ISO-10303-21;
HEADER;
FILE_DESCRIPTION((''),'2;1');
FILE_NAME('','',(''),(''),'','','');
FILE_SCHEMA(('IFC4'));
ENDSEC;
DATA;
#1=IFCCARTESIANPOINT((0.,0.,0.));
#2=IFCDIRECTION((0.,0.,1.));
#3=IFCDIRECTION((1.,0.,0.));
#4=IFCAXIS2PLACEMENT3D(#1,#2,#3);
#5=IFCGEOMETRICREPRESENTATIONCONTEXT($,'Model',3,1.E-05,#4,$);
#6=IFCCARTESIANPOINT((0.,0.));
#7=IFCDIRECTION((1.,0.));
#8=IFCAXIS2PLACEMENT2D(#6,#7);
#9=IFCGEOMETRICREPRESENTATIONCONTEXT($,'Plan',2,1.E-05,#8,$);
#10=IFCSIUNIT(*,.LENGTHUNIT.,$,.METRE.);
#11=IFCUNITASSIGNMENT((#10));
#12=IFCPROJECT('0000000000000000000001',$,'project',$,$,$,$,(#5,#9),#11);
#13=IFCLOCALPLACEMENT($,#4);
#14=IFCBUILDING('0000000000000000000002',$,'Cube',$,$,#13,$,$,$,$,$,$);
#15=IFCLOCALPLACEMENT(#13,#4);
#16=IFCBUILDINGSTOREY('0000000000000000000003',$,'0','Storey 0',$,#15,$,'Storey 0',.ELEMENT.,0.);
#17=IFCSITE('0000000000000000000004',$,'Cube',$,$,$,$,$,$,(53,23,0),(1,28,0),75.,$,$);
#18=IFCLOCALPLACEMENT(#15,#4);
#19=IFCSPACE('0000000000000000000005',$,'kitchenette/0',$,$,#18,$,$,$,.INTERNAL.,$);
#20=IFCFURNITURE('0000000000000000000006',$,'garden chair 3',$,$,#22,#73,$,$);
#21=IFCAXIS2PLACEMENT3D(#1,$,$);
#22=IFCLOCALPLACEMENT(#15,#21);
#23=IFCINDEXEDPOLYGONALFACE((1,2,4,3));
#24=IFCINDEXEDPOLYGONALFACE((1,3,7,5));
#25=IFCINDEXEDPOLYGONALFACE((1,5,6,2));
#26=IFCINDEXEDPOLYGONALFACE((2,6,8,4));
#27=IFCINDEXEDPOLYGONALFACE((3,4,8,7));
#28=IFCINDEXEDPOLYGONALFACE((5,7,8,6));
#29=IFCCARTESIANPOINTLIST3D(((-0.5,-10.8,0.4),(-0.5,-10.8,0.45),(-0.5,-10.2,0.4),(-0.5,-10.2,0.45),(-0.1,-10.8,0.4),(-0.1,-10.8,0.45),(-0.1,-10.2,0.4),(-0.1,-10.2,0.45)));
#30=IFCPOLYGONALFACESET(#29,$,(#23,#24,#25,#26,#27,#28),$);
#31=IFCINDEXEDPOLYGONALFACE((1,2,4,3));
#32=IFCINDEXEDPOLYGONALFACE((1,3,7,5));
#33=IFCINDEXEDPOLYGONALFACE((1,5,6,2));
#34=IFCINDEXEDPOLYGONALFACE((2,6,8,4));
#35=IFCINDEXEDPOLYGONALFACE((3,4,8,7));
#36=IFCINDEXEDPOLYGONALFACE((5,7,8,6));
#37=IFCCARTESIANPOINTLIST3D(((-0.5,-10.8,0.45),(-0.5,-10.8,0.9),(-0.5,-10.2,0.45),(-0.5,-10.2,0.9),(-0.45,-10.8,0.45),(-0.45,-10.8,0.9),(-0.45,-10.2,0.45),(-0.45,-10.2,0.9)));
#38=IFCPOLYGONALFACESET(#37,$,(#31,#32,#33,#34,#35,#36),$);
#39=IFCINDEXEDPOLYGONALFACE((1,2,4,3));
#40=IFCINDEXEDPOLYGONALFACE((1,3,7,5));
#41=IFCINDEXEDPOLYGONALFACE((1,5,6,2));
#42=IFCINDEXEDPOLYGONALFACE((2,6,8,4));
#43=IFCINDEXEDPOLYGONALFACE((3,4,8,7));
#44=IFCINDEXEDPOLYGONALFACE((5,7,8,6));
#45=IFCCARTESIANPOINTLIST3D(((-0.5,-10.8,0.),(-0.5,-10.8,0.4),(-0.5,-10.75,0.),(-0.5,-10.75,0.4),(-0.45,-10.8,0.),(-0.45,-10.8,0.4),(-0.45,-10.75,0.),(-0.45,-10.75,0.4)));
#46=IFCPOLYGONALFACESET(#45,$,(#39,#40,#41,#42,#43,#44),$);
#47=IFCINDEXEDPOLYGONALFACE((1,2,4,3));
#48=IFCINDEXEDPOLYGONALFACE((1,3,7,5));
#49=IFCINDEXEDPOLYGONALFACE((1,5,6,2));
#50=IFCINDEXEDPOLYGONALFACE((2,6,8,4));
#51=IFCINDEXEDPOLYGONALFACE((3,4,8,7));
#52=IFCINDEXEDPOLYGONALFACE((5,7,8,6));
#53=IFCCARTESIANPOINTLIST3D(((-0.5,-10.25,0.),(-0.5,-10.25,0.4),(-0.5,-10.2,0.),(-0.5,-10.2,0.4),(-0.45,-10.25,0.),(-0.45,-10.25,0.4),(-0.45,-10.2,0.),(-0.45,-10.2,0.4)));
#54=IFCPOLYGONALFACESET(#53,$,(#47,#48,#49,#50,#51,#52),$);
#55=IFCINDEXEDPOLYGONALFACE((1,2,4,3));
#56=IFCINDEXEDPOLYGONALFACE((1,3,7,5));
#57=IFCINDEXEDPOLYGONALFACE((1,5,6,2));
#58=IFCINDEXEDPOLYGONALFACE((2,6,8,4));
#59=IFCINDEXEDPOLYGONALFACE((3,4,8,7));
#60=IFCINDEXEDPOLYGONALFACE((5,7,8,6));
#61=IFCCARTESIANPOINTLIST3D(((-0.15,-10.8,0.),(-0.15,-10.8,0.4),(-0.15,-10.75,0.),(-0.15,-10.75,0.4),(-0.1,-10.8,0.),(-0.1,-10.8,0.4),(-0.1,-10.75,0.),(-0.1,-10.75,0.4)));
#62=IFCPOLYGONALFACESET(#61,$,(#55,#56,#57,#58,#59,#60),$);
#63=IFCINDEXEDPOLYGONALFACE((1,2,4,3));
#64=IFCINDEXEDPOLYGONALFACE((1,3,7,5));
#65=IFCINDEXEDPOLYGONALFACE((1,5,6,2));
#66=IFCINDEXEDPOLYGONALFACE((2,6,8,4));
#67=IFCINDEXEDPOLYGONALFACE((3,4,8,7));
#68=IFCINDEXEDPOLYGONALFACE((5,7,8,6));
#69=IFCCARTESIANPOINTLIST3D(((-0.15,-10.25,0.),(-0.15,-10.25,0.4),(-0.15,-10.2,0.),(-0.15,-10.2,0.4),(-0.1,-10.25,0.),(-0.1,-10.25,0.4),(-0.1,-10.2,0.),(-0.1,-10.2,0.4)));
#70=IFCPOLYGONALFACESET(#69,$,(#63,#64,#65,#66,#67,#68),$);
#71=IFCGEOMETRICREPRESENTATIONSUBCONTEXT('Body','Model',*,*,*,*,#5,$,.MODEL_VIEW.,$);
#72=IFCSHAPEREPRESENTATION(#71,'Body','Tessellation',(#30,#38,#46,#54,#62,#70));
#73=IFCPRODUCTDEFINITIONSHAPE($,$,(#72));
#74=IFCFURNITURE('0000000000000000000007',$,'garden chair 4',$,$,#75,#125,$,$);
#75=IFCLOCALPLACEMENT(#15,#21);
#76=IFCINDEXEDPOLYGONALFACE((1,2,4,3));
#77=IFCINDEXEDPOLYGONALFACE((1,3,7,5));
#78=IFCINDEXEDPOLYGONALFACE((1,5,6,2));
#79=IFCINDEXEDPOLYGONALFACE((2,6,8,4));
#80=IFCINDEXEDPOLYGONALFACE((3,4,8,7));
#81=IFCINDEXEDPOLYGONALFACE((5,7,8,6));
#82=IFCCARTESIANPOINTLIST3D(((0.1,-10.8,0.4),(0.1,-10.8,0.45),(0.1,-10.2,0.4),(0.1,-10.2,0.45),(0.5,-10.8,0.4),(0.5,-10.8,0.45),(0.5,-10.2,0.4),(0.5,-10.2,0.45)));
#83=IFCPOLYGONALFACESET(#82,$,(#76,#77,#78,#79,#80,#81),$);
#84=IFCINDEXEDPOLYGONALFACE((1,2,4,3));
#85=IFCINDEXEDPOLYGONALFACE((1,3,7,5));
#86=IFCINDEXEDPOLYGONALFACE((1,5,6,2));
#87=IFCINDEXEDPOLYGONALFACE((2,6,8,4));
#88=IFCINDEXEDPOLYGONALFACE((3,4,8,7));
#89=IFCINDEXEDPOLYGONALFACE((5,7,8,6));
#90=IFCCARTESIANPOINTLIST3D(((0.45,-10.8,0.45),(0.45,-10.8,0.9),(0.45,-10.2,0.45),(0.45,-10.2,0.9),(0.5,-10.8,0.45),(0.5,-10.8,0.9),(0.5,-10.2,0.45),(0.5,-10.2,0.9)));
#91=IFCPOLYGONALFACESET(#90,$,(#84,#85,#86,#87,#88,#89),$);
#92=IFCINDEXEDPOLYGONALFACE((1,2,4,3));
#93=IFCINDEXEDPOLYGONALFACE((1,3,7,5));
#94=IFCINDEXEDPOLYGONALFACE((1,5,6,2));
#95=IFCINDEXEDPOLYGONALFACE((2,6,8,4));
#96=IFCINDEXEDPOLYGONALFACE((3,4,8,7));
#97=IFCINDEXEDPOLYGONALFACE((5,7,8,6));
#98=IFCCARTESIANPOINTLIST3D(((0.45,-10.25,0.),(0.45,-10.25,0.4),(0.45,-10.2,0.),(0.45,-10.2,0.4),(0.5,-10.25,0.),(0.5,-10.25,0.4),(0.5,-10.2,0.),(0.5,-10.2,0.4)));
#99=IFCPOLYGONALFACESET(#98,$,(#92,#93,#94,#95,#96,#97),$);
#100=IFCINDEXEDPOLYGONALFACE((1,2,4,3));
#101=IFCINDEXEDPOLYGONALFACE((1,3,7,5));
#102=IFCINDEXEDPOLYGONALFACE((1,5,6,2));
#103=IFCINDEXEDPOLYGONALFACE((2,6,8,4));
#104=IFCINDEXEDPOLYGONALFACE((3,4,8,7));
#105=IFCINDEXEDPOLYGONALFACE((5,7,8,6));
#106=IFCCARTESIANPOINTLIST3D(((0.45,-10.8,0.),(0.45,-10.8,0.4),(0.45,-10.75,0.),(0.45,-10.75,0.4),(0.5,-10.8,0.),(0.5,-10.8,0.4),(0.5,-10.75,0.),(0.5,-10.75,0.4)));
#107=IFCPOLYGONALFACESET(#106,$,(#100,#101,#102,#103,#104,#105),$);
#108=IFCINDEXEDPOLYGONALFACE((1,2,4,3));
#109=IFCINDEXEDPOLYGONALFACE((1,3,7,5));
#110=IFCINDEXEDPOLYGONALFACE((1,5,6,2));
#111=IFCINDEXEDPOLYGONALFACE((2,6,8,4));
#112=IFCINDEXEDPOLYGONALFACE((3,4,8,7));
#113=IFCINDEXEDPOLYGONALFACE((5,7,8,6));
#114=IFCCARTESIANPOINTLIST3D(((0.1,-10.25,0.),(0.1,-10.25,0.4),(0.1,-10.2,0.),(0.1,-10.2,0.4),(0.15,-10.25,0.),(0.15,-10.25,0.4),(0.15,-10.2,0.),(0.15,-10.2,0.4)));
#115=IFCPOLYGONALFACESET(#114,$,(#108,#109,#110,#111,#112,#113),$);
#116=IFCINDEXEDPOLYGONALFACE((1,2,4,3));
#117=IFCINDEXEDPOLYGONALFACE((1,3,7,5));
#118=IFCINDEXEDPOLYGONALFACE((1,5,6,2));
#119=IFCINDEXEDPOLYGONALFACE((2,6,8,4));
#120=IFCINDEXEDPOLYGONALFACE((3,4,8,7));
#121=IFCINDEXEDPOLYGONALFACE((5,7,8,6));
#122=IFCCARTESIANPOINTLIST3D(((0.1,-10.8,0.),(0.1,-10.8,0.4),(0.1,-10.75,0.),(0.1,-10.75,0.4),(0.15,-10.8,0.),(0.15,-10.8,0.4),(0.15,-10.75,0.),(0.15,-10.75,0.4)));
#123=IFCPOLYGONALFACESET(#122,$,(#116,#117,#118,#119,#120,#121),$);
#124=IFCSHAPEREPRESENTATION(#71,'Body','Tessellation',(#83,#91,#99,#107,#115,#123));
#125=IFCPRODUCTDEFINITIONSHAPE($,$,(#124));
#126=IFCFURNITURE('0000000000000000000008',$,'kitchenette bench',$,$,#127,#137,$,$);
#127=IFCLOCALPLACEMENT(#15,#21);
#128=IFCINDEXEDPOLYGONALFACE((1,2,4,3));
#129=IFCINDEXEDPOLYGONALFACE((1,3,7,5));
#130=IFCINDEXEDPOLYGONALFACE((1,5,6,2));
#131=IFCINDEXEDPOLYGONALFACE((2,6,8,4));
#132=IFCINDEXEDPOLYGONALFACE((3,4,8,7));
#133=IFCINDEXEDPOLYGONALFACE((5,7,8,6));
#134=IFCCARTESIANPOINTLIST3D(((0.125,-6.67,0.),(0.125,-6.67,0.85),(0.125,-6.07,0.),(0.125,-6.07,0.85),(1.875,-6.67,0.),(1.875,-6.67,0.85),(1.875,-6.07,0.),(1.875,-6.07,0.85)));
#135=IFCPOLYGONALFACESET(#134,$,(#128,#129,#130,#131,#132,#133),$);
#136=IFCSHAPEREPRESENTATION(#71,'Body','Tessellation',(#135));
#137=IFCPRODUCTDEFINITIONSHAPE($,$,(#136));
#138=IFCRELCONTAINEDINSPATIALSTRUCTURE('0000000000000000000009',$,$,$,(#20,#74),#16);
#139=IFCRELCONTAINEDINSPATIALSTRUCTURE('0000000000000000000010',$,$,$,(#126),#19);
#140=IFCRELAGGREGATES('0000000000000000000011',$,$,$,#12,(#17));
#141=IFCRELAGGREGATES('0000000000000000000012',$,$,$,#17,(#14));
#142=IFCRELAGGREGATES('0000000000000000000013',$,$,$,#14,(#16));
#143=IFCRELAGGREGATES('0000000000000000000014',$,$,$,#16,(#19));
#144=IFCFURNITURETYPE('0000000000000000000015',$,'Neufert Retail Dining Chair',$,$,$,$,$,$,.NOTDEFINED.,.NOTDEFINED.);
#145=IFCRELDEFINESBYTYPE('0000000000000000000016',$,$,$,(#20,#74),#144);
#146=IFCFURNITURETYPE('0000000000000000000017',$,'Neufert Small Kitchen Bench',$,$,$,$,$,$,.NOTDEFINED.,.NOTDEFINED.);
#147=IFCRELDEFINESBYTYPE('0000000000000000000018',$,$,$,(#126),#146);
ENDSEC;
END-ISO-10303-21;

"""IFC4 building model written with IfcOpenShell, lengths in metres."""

from ifc_helpers import new_model, entity, si_unit, frame, origin_with_axes, origin_2d_with_axis, place, context, subcontext, project, spatial, line, indexed_curve, outline, extrude, shape, source, transform, mapped, type_object, type_shapes, element, save


model = new_model("IFC4")

# Units and contexts
model_context = context("Model", 3, precision=1e-05, world=origin_with_axes())
plan_context = context("Plan", 2, precision=1e-05, world=origin_2d_with_axis())
body_context_1 = subcontext(model_context, "Body", "Model", "MODEL_VIEW")
body_context_2 = subcontext(plan_context, "Body", "Plan", "PLAN_VIEW")
ifc_project = project(units=[si_unit("LENGTHUNIT", "METRE")], contexts=[model_context, plan_context])

# Site, building, storey
site = spatial("IfcSite", under=ifc_project, Name="Cube", RefLatitude=(53, 23, 0), RefLongitude=(1, 28, 0), RefElevation=75.0)
building_placement = place(None, origin_with_axes())
building = spatial("IfcBuilding", under=site, at=building_placement, Name="Cube")
storey_placement = place(building_placement, origin_with_axes())
storey = spatial("IfcBuildingStorey", under=building, at=storey_placement, Name="0", Description="Storey 0", LongName="Storey 0", CompositionType="ELEMENT", Elevation=0.0)

# Shared definitions
space_1_placement = place(storey_placement, origin_with_axes())
space_1 = spatial("IfcSpace", under=storey, at=space_1_placement, Name="kitchenette/0", PredefinedType="INTERNAL")

# Furniture
furniture_type_1 = type_object("IfcFurnitureType", Name="Neufert Retail Dining Chair", AssemblyPlace="NOTDEFINED", PredefinedType="NOTDEFINED")
shared_shape_1 = source(origin_with_axes(), body_context_1, "Body", "SweptSolid", [
    extrude(outline(indexed_curve([(-0.3, 0.0), (0.3, 0.0), (0.3, -0.4), (-0.3, -0.4)], segments=[line(1, 2, 3, 4, 1)])), frame((0.0, 0.0, 0.45), z_axis=(0.0, 0.0, 1.0), x_axis=(1.0, 0.0, 0.0)), (0.0, 0.0, -1.0), 0.05),
    extrude(outline(indexed_curve([(-0.3, 0.0), (0.3, 0.0), (0.3, -0.05), (-0.3, -0.05)], segments=[line(1, 2, 3, 4, 1)])), frame((0.0, 0.0, 0.9), z_axis=(0.0, 0.0, 1.0), x_axis=(1.0, 0.0, 0.0)), (0.0, 0.0, -1.0), 0.45),
    extrude(outline(indexed_curve([(-0.3, 0.0), (-0.25, 0.0), (-0.25, -0.05), (-0.3, -0.05)], segments=[line(1, 2, 3, 4, 1)])), origin_with_axes(), (0.0, 0.0, 1.0), 0.4),
    extrude(outline(indexed_curve([(0.3, 0.0), (0.25, 0.0), (0.25, -0.05), (0.3, -0.05)], segments=[line(1, 2, 3, 4, 1)])), origin_with_axes(), (0.0, 0.0, 1.0), 0.4),
    extrude(outline(indexed_curve([(-0.3, -0.4), (-0.25, -0.4), (-0.25, -0.35), (-0.3, -0.35)], segments=[line(1, 2, 3, 4, 1)])), origin_with_axes(), (0.0, 0.0, 1.0), 0.4),
    extrude(outline(indexed_curve([(0.3, -0.4), (0.25, -0.4), (0.25, -0.35), (0.3, -0.35)], segments=[line(1, 2, 3, 4, 1)])), origin_with_axes(), (0.0, 0.0, 1.0), 0.4),
])
shared_shape_2 = source(origin_with_axes(), body_context_2, "Body", "Curve2D", [
    entity("IfcIndexedPolyCurve", entity("IfcCartesianPointList2D", [[-0.3, -0.4], [0.3, -0.4]])),
    entity("IfcIndexedPolyCurve", entity("IfcCartesianPointList2D", [[-0.3, -0.4], [-0.3, -0.3], [-0.2121, -0.0879], [0.0, 0.0], [0.2121, -0.0879], [0.3, -0.3], [0.3, -0.4]]), [entity("IfcLineIndex", [1, 2]), entity("IfcArcIndex", [2, 3, 4]), entity("IfcArcIndex", [4, 5, 6]), entity("IfcLineIndex", [6, 7])]),
    entity("IfcIndexedPolyCurve", entity("IfcCartesianPointList2D", [[-0.26, -0.4], [-0.26, -0.3], [-0.1838, -0.1162], [0.0, -0.04], [0.1838, -0.1162], [0.26, -0.3], [0.26, -0.4]]), [entity("IfcLineIndex", [1, 2]), entity("IfcArcIndex", [2, 3, 4]), entity("IfcArcIndex", [4, 5, 6]), entity("IfcLineIndex", [6, 7])]),
])
type_shapes(furniture_type_1, [shared_shape_1, shared_shape_2])
for number, where, z_axis, x_axis, name in (
    (1, (-0.5, -10.5, 0.0), (0.0, 0.0, 1.0), (0.0, 1.0, 0.0), "garden chair 3"),
    (2, (0.5, -10.5, 0.0), (0.0, 0.0, 1.0), (0.0, -1.0, 0.0), "garden chair 4"),
):
    element("IfcFurniture", number, at=place(storey_placement, frame(where, z_axis=z_axis, x_axis=x_axis)), inside=storey, type_object=furniture_type_1, Name=name, shapes=[
        shape(body_context_1, "Body", "MappedRepresentation", [mapped(shared_shape_1, transform((0.0, 0.0, 0.0), x_axis=(1.0, 0.0, 0.0), y_axis=(0.0, 1.0, 0.0), z_axis=(0.0, 0.0, 1.0), scale=1.0))]),
        shape(body_context_2, "Body", "MappedRepresentation", [mapped(shared_shape_2, transform((0.0, 0.0, 0.0), x_axis=(1.0, 0.0, 0.0), y_axis=(0.0, 1.0, 0.0), z_axis=(0.0, 0.0, 1.0), scale=1.0))]),
    ])
furniture_type_2 = type_object("IfcFurnitureType", Name="Neufert Small Kitchen Bench", AssemblyPlace="NOTDEFINED", PredefinedType="NOTDEFINED")
shared_shape_3 = source(origin_with_axes(), body_context_1, "Body", "SweptSolid", [
    extrude(outline(indexed_curve([(0.0, 0.0), (1.75, 0.0), (1.75, 0.6), (0.0, 0.6)], segments=[line(1, 2, 3, 4, 1)])), origin_with_axes(), (0.0, 0.0, 1.0), 0.85),
])
shared_shape_4 = source(origin_with_axes(), body_context_2, "Body", "Curve2D", [
    entity("IfcIndexedPolyCurve", entity("IfcCartesianPointList2D", [[0.0, 0.0], [1.75, 0.0], [1.75, 0.6], [0.0, 0.6]]), [entity("IfcLineIndex", [1, 2, 3, 4, 1])]),
])
type_shapes(furniture_type_2, [shared_shape_3, shared_shape_4])
furniture_placement = place(space_1_placement, frame((0.125, -6.67, 0.0), z_axis=(0.0, 0.0, 1.0), x_axis=(1.0, 0.0, 0.0)))
element("IfcFurniture", 3, at=furniture_placement, inside=space_1, type_object=furniture_type_2, Name="kitchenette bench", shapes=[
    shape(body_context_1, "Body", "MappedRepresentation", [mapped(shared_shape_3, transform((0.0, 0.0, 0.0), x_axis=(1.0, 0.0, 0.0), y_axis=(0.0, 1.0, 0.0), z_axis=(0.0, 0.0, 1.0), scale=1.0))]),
    shape(body_context_2, "Body", "MappedRepresentation", [mapped(shared_shape_4, transform((0.0, 0.0, 0.0), x_axis=(1.0, 0.0, 0.0), y_axis=(0.0, 1.0, 0.0), z_axis=(0.0, 0.0, 1.0), scale=1.0))]),
])

save(model, "model.ifc")
